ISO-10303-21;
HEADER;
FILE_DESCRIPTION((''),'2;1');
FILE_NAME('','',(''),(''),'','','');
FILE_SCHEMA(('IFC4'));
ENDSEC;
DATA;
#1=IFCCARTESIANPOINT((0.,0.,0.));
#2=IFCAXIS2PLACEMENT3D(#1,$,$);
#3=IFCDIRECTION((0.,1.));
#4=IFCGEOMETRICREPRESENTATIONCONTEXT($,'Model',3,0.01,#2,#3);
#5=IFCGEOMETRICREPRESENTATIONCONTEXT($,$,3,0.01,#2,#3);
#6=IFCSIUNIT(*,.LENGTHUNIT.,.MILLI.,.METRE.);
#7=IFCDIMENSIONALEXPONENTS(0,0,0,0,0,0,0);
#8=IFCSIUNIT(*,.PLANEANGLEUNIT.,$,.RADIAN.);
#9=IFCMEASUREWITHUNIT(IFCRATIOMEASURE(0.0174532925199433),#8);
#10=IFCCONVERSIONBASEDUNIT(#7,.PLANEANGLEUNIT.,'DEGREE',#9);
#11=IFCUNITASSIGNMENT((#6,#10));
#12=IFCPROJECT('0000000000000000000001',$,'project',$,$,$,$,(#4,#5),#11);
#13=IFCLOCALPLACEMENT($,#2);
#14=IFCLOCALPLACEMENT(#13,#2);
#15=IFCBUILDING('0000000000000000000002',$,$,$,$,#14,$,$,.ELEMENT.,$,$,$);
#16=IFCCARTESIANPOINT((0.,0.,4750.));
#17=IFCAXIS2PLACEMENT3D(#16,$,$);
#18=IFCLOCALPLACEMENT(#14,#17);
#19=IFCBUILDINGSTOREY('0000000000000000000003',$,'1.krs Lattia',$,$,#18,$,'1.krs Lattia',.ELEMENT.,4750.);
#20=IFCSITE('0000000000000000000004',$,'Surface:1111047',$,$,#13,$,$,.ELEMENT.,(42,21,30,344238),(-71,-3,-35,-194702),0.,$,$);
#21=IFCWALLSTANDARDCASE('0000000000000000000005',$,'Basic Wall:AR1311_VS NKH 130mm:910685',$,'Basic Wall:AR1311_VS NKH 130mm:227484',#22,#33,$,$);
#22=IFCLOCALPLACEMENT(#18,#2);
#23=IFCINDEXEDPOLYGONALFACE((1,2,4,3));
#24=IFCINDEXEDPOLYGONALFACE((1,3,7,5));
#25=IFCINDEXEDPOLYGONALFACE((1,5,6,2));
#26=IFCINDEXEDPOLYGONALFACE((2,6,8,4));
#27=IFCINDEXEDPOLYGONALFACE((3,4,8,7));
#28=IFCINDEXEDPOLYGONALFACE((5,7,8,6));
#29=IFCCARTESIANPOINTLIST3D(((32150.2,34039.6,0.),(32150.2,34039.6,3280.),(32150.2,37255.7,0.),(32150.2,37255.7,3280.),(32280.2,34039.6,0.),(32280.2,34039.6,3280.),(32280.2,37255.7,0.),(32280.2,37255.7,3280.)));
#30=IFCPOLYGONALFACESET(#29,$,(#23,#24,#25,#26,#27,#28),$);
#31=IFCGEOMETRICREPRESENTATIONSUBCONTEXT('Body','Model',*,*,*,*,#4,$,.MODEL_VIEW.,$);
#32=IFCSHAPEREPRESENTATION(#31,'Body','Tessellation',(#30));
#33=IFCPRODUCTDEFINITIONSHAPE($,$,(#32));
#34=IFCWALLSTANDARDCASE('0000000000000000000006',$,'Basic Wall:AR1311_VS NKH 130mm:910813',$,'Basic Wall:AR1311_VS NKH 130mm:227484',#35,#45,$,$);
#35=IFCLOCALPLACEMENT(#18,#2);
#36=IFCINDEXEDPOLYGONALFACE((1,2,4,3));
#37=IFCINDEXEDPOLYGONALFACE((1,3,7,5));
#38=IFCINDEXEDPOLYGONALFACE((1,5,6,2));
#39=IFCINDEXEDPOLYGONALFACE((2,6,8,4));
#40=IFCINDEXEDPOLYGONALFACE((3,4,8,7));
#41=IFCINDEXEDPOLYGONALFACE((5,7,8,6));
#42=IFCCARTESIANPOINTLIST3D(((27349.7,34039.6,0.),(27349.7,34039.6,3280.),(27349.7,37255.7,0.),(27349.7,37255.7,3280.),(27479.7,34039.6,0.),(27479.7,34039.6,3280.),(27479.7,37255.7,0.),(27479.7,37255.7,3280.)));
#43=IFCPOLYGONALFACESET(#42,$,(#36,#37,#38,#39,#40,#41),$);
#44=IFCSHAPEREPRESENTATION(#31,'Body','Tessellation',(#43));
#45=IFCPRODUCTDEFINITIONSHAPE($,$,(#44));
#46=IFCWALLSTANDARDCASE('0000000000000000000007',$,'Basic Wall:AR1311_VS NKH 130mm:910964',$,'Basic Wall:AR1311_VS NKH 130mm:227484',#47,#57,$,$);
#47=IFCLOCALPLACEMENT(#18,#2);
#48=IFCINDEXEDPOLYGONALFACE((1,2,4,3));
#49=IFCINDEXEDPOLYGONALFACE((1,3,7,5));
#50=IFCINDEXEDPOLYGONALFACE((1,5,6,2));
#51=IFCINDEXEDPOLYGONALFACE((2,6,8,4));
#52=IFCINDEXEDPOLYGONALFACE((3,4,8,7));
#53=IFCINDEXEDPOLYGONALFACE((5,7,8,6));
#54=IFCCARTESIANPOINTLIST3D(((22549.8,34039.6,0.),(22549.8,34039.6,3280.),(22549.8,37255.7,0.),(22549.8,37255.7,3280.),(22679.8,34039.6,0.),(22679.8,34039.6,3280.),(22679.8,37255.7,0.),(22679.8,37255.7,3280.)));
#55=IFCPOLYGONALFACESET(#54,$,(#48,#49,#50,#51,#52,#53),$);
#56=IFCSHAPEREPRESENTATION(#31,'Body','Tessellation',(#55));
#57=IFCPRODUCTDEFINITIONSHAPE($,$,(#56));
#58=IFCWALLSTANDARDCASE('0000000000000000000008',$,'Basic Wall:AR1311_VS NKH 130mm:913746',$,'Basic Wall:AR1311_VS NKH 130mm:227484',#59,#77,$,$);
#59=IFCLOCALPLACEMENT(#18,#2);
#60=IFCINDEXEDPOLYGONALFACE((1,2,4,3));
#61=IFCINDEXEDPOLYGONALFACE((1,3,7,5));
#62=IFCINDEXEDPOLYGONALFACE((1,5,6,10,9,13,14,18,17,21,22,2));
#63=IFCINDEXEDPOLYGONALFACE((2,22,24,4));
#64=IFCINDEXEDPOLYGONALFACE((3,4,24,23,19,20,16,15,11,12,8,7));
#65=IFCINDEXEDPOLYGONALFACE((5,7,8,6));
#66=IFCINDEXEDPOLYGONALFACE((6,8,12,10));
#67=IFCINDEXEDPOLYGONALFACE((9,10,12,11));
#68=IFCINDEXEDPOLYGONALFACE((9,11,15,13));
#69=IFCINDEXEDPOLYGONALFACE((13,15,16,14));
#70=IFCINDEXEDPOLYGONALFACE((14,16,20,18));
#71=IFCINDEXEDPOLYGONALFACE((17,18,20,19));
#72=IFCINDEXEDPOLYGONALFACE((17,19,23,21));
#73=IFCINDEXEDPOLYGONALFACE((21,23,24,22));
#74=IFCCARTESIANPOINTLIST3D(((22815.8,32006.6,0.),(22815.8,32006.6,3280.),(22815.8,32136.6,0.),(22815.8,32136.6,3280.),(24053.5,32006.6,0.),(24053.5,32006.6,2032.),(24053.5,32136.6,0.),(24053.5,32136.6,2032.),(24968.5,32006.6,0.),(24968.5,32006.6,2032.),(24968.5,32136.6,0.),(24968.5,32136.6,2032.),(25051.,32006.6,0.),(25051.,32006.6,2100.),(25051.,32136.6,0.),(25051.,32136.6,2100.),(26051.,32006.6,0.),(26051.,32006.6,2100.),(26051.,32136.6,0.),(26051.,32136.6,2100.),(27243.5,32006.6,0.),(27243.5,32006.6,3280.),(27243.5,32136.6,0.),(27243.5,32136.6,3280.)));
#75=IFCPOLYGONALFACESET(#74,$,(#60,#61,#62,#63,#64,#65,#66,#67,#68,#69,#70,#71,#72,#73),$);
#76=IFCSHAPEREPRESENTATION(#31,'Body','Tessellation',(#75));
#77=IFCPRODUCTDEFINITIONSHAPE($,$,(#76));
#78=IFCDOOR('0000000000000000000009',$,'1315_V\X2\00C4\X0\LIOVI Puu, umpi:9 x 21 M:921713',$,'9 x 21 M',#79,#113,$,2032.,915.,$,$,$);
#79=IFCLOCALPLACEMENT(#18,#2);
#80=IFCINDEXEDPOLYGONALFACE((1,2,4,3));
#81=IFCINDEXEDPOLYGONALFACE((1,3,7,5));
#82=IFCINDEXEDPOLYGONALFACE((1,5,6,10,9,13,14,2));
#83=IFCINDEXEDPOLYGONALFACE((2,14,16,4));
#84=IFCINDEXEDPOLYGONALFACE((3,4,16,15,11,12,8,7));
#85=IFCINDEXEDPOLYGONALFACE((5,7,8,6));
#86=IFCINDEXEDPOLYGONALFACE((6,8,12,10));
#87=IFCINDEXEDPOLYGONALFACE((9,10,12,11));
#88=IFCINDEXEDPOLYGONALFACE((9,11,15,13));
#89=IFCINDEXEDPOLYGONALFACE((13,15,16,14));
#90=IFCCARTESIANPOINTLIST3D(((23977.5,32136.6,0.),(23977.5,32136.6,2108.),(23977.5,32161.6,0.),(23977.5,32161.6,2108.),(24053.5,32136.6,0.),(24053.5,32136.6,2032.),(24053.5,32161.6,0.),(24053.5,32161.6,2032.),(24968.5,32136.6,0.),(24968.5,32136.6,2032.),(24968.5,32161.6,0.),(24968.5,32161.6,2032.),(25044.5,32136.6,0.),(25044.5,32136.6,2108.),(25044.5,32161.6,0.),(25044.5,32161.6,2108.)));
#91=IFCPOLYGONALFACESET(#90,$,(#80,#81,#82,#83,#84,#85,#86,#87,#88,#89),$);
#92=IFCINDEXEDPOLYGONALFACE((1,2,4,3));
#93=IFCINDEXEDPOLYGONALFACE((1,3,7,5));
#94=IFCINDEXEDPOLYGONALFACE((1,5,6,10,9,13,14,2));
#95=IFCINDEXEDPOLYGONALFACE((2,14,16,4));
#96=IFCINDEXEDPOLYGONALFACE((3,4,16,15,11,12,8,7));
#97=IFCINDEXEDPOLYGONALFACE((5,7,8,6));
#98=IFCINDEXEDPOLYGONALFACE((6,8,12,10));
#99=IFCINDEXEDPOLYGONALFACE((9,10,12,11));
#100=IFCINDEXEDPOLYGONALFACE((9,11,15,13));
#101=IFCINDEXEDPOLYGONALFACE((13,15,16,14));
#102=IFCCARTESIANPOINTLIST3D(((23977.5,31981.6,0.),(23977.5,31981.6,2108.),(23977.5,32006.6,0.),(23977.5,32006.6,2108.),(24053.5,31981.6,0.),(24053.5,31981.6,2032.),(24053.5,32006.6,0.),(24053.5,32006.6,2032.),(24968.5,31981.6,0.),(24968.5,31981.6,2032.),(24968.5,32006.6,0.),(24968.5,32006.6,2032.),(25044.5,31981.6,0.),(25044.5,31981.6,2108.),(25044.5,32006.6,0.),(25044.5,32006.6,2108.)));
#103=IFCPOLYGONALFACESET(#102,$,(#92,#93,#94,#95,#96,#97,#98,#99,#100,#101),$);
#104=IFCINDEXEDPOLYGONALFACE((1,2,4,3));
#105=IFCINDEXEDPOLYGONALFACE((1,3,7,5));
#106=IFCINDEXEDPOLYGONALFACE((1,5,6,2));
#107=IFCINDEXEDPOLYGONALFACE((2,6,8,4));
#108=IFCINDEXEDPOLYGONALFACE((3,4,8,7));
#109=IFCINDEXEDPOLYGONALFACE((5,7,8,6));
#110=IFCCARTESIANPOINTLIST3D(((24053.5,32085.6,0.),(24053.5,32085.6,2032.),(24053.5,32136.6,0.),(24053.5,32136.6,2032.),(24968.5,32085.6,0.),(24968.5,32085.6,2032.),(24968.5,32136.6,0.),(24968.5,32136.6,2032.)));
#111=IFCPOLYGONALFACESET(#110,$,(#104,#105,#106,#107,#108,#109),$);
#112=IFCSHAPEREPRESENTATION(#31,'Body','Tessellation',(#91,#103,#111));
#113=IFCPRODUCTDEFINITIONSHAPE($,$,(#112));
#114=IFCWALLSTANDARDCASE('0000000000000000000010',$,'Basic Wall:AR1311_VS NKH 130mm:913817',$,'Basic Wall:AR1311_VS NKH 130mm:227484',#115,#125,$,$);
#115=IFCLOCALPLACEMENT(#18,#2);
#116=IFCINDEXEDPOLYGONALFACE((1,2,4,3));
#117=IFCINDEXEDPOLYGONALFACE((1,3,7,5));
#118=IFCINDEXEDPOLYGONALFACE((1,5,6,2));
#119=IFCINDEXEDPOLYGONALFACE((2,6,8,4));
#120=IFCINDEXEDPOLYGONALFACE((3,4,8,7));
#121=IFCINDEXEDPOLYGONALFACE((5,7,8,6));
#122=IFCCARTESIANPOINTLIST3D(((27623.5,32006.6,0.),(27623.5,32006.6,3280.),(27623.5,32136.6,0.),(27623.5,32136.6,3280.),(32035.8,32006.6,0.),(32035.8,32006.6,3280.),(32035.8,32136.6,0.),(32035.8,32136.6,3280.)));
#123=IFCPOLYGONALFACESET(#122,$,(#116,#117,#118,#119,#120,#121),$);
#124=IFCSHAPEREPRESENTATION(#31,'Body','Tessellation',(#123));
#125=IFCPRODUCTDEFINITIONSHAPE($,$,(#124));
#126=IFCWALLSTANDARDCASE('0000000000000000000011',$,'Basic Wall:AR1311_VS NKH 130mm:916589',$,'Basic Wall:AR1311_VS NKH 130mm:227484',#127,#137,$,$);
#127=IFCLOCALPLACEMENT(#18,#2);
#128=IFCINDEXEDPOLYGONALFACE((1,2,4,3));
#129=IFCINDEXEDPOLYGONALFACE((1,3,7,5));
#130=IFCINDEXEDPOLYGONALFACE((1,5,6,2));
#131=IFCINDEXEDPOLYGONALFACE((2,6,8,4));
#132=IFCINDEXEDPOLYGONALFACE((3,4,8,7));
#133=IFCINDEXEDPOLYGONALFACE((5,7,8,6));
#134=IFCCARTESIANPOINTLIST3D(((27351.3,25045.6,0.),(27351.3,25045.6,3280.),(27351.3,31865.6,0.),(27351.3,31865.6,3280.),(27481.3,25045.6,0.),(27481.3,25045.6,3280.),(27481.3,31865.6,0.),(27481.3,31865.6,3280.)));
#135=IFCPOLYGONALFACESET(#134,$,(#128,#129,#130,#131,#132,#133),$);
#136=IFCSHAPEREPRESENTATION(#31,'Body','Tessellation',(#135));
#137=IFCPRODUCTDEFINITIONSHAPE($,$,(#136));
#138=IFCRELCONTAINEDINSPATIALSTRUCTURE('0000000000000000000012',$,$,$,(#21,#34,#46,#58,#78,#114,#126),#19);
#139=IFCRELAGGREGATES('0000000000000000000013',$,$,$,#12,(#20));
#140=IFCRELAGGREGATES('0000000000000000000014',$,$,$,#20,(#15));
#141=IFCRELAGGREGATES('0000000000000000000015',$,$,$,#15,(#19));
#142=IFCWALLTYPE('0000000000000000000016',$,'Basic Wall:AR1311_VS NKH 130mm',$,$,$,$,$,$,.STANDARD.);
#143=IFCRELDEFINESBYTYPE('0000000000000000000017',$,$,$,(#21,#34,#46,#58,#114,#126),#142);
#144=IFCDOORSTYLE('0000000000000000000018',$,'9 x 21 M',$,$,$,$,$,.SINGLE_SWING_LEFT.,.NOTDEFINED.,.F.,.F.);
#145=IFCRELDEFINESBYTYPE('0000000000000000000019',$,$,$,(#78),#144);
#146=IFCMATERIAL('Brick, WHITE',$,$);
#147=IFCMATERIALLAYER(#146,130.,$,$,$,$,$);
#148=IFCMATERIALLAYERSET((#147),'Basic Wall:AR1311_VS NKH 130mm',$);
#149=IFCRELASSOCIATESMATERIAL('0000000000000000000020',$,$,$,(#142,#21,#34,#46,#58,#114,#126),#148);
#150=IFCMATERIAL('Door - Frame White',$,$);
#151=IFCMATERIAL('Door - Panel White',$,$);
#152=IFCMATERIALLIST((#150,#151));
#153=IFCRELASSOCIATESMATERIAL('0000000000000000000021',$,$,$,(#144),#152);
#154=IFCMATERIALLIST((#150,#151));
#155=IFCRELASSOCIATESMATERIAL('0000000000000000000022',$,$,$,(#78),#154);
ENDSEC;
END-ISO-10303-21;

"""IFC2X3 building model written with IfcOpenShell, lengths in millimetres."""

from ifc_helpers import new_model, entity, si_unit, converted_unit, direction, frame, frame_2d, origin, place, context, subcontext, project, spatial, polyline, rectangle, outline, extrude, clip, bounded_halfspace, source, transform, mapped, material, material_list, layer, layer_set, layer_usage, type_object, type_shapes, element, fill, save


model = new_model("IFC2X3")

# Units and contexts
model_context = context("Model", 3, precision=0.01, world=origin(), true_north=direction((0.0, 1.0)))
context_of_model = context(None, 3, precision=0.01, world=origin(), true_north=direction((0.0, 1.0)))
body_context = subcontext(model_context, "Body", "Model", "MODEL_VIEW")
ifc_project = project(units=[si_unit("LENGTHUNIT", "METRE", prefix="MILLI"), converted_unit("PLANEANGLEUNIT", "DEGREE", entity("IfcRatioMeasure", 0.0174532925199433), si_unit("PLANEANGLEUNIT", "RADIAN"), dimensions=[0, 0, 0, 0, 0, 0, 0])], contexts=[model_context, context_of_model])

# Site, building, storey
site_placement = place(None, origin())
site = spatial("IfcSite", under=ifc_project, at=site_placement, Name="Surface:1111047", CompositionType="ELEMENT", RefLatitude=(42, 21, 30, 344238), RefLongitude=(-71, -3, -35, -194702), RefElevation=0.0)
building_placement = place(site_placement, origin())
building = spatial("IfcBuilding", under=site, at=building_placement, CompositionType="ELEMENT")
storey_placement = place(building_placement, frame((0.0, 0.0, 4750.0)))
storey = spatial("IfcBuildingStorey", under=building, at=storey_placement, Name="1.krs Lattia", LongName="1.krs Lattia", CompositionType="ELEMENT", Elevation=4750.0)

# Walls
ifc_material_1 = material(Name="Brick, WHITE")
ifc_layer = layer(ifc_material_1, 130.0)
ifc_layer_set = layer_set([ifc_layer], Name="Basic Wall:AR1311_VS NKH 130mm")
wall_type = type_object("IfcWallType", Name="Basic Wall:AR1311_VS NKH 130mm", PredefinedType="STANDARD", material=ifc_layer_set)
ifc_layer_usage_1 = layer_usage(ifc_layer_set, "AXIS2", "NEGATIVE", 65.0)
wall_1_placement = place(storey_placement, frame((32215.2, 37255.7, 0.0), z_axis=(0.0, 0.0, 1.0), x_axis=(0.0, -1.0, 0.0)))
element("IfcWallStandardCase", 1, at=wall_1_placement, inside=storey, type_object=wall_type, material=ifc_layer_usage_1, Name="Basic Wall:AR1311_VS NKH 130mm:910685", ObjectType="Basic Wall:AR1311_VS NKH 130mm:227484", context=body_context, shape_type="Clipping", body=[
    clip(extrude(rectangle(XDim=3216.1, YDim=130.0, at=frame_2d((1608.1, 0.0), x_axis=(-1.0, 0.0))), origin(), (0.0, 0.0, 1.0), 3280.0), bounded_halfspace(frame((0.0, -65.0, 3280.0), z_axis=(0.0, 0.0, -1.0), x_axis=(-1.0, 0.0, 0.0)), True, frame((0.0, -65.0, 3280.0)), polyline([(0.0, 0.0), (3216.1, 0.0), (3216.1, 130.0), (0.0, 130.0), (0.0, 0.0)]))),
])
ifc_layer_usage_2 = layer_usage(ifc_layer_set, "AXIS2", "NEGATIVE", 65.0)
wall_2_placement = place(storey_placement, frame((27414.7, 37255.7, 0.0), z_axis=(0.0, 0.0, 1.0), x_axis=(0.0, -1.0, 0.0)))
element("IfcWallStandardCase", 2, at=wall_2_placement, inside=storey, type_object=wall_type, material=ifc_layer_usage_2, Name="Basic Wall:AR1311_VS NKH 130mm:910813", ObjectType="Basic Wall:AR1311_VS NKH 130mm:227484", context=body_context, shape_type="Clipping", body=[
    clip(extrude(rectangle(XDim=3216.1, YDim=130.0, at=frame_2d((1608.1, 0.0), x_axis=(-1.0, 0.0))), origin(), (0.0, 0.0, 1.0), 3280.0), bounded_halfspace(frame((0.0, -65.0, 3280.0), z_axis=(0.0, 0.0, -1.0), x_axis=(-1.0, 0.0, 0.0)), True, frame((0.0, -65.0, 3280.0)), polyline([(0.0, 0.0), (3216.1, 0.0), (3216.1, 130.0), (0.0, 130.0), (0.0, 0.0)]))),
])
ifc_layer_usage_3 = layer_usage(ifc_layer_set, "AXIS2", "NEGATIVE", 65.0)
wall_3_placement = place(storey_placement, frame((22614.8, 37255.7, 0.0), z_axis=(0.0, 0.0, 1.0), x_axis=(0.0, -1.0, 0.0)))
element("IfcWallStandardCase", 3, at=wall_3_placement, inside=storey, type_object=wall_type, material=ifc_layer_usage_3, Name="Basic Wall:AR1311_VS NKH 130mm:910964", ObjectType="Basic Wall:AR1311_VS NKH 130mm:227484", context=body_context, shape_type="Clipping", body=[
    clip(extrude(rectangle(XDim=3216.1, YDim=130.0, at=frame_2d((1608.1, 0.0), x_axis=(-1.0, 0.0))), origin(), (0.0, 0.0, 1.0), 3280.0), bounded_halfspace(frame((0.0, -65.0, 3280.0), z_axis=(0.0, 0.0, -1.0), x_axis=(-1.0, 0.0, 0.0)), True, frame((0.0, -65.0, 3280.0)), polyline([(0.0, 0.0), (3216.1, 0.0), (3216.1, 130.0), (0.0, 130.0), (0.0, 0.0)]))),
])

# Wall, openings, door
ifc_layer_usage_4 = layer_usage(ifc_layer_set, "AXIS2", "NEGATIVE", 65.0)
wall_4_placement = place(storey_placement, frame((22815.8, 32071.6, 0.0)))
wall_4 = element("IfcWallStandardCase", 4, at=wall_4_placement, inside=storey, type_object=wall_type, material=ifc_layer_usage_4, Name="Basic Wall:AR1311_VS NKH 130mm:913746", ObjectType="Basic Wall:AR1311_VS NKH 130mm:227484", context=body_context, shape_type="Clipping", body=[
    clip(extrude(rectangle(XDim=4427.8, YDim=130.0, at=frame_2d((2213.9, 0.0), x_axis=(-1.0, 0.0))), origin(), (0.0, 0.0, 1.0), 3280.0), bounded_halfspace(frame((0.0, -65.0, 3280.0), z_axis=(0.0, 0.0, -1.0), x_axis=(0.0, 1.0, 0.0)), True, frame((0.0, -65.0, 3280.0)), polyline([(0.0, 0.0), (4427.8, 0.0), (4427.8, 130.0), (0.0, 130.0), (0.0, 0.0)]))),
])
opening_1_placement = place(wall_4_placement, origin())
element("IfcOpeningElement", 5, at=opening_1_placement, cuts=wall_4, ObjectType="Opening", context=body_context, shape_type="SweptSolid", body=[
    extrude(rectangle(XDim=2107.4, YDim=1000.0, at=frame_2d((0.0, 0.0), x_axis=(1.0, 0.0))), frame((2735.3, -65.0, 1046.3), z_axis=(0.0, 1.0, 0.0), x_axis=(0.0, 0.0, -1.0)), (0.0, 0.0, 1.0), 130.0),
])
opening_2_placement = place(wall_4_placement, frame((1237.8, -65.0, 0.0)))
opening_2 = element("IfcOpeningElement", 6, at=opening_2_placement, cuts=wall_4, ObjectType="Opening", context=body_context, shape_type="SweptSolid", body=[
    extrude(rectangle(XDim=915.0, YDim=2032.0, at=frame_2d((1016.0, 457.5), x_axis=(0.0, -1.0))), frame((0.0, 0.0, 0.0), z_axis=(0.0, 1.0, 0.0), x_axis=(0.0, 0.0, 1.0)), (0.0, 0.0, 1.0), 130.0),
])
ifc_material_2 = material(Name="Door - Frame White")
ifc_material_3 = material(Name="Door - Panel White")
ifc_material_list_1 = material_list([ifc_material_2, ifc_material_3])
ifc_material_list_2 = material_list([ifc_material_2, ifc_material_3])
door_style = type_object("IfcDoorStyle", Name="9 x 21 M", ConstructionType="NOTDEFINED", OperationType="SINGLE_SWING_LEFT", ParameterTakesPrecedence=False, Sizeable=False, material=ifc_material_list_2)
shared_shape_1 = source(origin(), body_context, "Body", "SweptSolid", [
    extrude(outline(polyline([(-533.5, -1073.0), (533.5, -1073.0), (533.5, 1035.0), (457.5, 1035.0), (457.5, -997.0), (-457.5, -997.0), (-457.5, 1035.0), (-533.5, 1035.0), (-533.5, -1073.0)])), frame((457.5, 155.0, 1035.0), z_axis=(0.0, -1.0, 0.0), x_axis=(-1.0, 0.0, 0.0)), (0.0, 0.0, 1.0), 25.0),
    extrude(outline(polyline([(-1073.0, -533.5), (1035.0, -533.5), (1035.0, -457.5), (-997.0, -457.5), (-997.0, 457.5), (1035.0, 457.5), (1035.0, 533.5), (-1073.0, 533.5), (-1073.0, -533.5)])), frame((457.5, 0.0, 1035.0), z_axis=(0.0, -1.0, 0.0), x_axis=(0.0, 0.0, -1.0)), (0.0, 0.0, 1.0), 25.0),
    extrude(rectangle(XDim=915.0, YDim=51.0, at=frame_2d((0.0, 0.0), x_axis=(1.0, 0.0))), frame((457.5, 104.5, 0.0)), (0.0, 0.0, 1.0), 2032.0),
])
type_shapes(door_style, [shared_shape_1])
door_1_placement = place(opening_2_placement, origin())
door_1 = element("IfcDoor", 7, at=door_1_placement, inside=storey, type_object=door_style, material=ifc_material_list_1, Name="1315_VÄLIOVI Puu, umpi:9 x 21 M:921713", ObjectType="9 x 21 M", OverallHeight=2032.0, OverallWidth=915.0, context=body_context, shape_type="MappedRepresentation", body=[
    mapped(shared_shape_1, transform((0.0, 0.0, 0.0), scale=1.0)),
])
fill(opening_2, door_1)

# Walls
ifc_layer_usage_5 = layer_usage(ifc_layer_set, "AXIS2", "NEGATIVE", 65.0)
wall_5_placement = place(storey_placement, frame((27623.5, 32071.6, 0.0)))
element("IfcWallStandardCase", 8, at=wall_5_placement, inside=storey, type_object=wall_type, material=ifc_layer_usage_5, Name="Basic Wall:AR1311_VS NKH 130mm:913817", ObjectType="Basic Wall:AR1311_VS NKH 130mm:227484", context=body_context, shape_type="Clipping", body=[
    clip(extrude(rectangle(XDim=4412.2, YDim=130.0, at=frame_2d((2206.1, 0.0), x_axis=(-1.0, 0.0))), origin(), (0.0, 0.0, 1.0), 3280.0), bounded_halfspace(frame((0.0, -65.0, 3280.0), z_axis=(0.0, 0.0, -1.0), x_axis=(0.0, 1.0, 0.0)), True, frame((0.0, -65.0, 3280.0)), polyline([(0.0, 0.0), (4412.2, 0.0), (4412.2, 130.0), (0.0, 130.0), (0.0, 0.0)]))),
])
ifc_layer_usage_6 = layer_usage(ifc_layer_set, "AXIS2", "NEGATIVE", 65.0)
wall_6_placement = place(storey_placement, frame((27416.3, 31865.6, 0.0), z_axis=(0.0, 0.0, 1.0), x_axis=(0.0, -1.0, 0.0)))
element("IfcWallStandardCase", 9, at=wall_6_placement, inside=storey, type_object=wall_type, material=ifc_layer_usage_6, Name="Basic Wall:AR1311_VS NKH 130mm:916589", ObjectType="Basic Wall:AR1311_VS NKH 130mm:227484", context=body_context, shape_type="Clipping", body=[
    clip(extrude(rectangle(XDim=6820.0, YDim=130.0, at=frame_2d((3410.0, 0.0), x_axis=(-1.0, 0.0))), origin(), (0.0, 0.0, 1.0), 3280.0), bounded_halfspace(frame((0.0, -65.0, 3280.0), z_axis=(0.0, 0.0, -1.0), x_axis=(-1.0, 0.0, 0.0)), True, frame((0.0, -65.0, 3280.0)), polyline([(0.0, 0.0), (6820.0, 0.0), (6820.0, 130.0), (0.0, 130.0), (0.0, 0.0)]))),
])

save(model, "model.ifc")
